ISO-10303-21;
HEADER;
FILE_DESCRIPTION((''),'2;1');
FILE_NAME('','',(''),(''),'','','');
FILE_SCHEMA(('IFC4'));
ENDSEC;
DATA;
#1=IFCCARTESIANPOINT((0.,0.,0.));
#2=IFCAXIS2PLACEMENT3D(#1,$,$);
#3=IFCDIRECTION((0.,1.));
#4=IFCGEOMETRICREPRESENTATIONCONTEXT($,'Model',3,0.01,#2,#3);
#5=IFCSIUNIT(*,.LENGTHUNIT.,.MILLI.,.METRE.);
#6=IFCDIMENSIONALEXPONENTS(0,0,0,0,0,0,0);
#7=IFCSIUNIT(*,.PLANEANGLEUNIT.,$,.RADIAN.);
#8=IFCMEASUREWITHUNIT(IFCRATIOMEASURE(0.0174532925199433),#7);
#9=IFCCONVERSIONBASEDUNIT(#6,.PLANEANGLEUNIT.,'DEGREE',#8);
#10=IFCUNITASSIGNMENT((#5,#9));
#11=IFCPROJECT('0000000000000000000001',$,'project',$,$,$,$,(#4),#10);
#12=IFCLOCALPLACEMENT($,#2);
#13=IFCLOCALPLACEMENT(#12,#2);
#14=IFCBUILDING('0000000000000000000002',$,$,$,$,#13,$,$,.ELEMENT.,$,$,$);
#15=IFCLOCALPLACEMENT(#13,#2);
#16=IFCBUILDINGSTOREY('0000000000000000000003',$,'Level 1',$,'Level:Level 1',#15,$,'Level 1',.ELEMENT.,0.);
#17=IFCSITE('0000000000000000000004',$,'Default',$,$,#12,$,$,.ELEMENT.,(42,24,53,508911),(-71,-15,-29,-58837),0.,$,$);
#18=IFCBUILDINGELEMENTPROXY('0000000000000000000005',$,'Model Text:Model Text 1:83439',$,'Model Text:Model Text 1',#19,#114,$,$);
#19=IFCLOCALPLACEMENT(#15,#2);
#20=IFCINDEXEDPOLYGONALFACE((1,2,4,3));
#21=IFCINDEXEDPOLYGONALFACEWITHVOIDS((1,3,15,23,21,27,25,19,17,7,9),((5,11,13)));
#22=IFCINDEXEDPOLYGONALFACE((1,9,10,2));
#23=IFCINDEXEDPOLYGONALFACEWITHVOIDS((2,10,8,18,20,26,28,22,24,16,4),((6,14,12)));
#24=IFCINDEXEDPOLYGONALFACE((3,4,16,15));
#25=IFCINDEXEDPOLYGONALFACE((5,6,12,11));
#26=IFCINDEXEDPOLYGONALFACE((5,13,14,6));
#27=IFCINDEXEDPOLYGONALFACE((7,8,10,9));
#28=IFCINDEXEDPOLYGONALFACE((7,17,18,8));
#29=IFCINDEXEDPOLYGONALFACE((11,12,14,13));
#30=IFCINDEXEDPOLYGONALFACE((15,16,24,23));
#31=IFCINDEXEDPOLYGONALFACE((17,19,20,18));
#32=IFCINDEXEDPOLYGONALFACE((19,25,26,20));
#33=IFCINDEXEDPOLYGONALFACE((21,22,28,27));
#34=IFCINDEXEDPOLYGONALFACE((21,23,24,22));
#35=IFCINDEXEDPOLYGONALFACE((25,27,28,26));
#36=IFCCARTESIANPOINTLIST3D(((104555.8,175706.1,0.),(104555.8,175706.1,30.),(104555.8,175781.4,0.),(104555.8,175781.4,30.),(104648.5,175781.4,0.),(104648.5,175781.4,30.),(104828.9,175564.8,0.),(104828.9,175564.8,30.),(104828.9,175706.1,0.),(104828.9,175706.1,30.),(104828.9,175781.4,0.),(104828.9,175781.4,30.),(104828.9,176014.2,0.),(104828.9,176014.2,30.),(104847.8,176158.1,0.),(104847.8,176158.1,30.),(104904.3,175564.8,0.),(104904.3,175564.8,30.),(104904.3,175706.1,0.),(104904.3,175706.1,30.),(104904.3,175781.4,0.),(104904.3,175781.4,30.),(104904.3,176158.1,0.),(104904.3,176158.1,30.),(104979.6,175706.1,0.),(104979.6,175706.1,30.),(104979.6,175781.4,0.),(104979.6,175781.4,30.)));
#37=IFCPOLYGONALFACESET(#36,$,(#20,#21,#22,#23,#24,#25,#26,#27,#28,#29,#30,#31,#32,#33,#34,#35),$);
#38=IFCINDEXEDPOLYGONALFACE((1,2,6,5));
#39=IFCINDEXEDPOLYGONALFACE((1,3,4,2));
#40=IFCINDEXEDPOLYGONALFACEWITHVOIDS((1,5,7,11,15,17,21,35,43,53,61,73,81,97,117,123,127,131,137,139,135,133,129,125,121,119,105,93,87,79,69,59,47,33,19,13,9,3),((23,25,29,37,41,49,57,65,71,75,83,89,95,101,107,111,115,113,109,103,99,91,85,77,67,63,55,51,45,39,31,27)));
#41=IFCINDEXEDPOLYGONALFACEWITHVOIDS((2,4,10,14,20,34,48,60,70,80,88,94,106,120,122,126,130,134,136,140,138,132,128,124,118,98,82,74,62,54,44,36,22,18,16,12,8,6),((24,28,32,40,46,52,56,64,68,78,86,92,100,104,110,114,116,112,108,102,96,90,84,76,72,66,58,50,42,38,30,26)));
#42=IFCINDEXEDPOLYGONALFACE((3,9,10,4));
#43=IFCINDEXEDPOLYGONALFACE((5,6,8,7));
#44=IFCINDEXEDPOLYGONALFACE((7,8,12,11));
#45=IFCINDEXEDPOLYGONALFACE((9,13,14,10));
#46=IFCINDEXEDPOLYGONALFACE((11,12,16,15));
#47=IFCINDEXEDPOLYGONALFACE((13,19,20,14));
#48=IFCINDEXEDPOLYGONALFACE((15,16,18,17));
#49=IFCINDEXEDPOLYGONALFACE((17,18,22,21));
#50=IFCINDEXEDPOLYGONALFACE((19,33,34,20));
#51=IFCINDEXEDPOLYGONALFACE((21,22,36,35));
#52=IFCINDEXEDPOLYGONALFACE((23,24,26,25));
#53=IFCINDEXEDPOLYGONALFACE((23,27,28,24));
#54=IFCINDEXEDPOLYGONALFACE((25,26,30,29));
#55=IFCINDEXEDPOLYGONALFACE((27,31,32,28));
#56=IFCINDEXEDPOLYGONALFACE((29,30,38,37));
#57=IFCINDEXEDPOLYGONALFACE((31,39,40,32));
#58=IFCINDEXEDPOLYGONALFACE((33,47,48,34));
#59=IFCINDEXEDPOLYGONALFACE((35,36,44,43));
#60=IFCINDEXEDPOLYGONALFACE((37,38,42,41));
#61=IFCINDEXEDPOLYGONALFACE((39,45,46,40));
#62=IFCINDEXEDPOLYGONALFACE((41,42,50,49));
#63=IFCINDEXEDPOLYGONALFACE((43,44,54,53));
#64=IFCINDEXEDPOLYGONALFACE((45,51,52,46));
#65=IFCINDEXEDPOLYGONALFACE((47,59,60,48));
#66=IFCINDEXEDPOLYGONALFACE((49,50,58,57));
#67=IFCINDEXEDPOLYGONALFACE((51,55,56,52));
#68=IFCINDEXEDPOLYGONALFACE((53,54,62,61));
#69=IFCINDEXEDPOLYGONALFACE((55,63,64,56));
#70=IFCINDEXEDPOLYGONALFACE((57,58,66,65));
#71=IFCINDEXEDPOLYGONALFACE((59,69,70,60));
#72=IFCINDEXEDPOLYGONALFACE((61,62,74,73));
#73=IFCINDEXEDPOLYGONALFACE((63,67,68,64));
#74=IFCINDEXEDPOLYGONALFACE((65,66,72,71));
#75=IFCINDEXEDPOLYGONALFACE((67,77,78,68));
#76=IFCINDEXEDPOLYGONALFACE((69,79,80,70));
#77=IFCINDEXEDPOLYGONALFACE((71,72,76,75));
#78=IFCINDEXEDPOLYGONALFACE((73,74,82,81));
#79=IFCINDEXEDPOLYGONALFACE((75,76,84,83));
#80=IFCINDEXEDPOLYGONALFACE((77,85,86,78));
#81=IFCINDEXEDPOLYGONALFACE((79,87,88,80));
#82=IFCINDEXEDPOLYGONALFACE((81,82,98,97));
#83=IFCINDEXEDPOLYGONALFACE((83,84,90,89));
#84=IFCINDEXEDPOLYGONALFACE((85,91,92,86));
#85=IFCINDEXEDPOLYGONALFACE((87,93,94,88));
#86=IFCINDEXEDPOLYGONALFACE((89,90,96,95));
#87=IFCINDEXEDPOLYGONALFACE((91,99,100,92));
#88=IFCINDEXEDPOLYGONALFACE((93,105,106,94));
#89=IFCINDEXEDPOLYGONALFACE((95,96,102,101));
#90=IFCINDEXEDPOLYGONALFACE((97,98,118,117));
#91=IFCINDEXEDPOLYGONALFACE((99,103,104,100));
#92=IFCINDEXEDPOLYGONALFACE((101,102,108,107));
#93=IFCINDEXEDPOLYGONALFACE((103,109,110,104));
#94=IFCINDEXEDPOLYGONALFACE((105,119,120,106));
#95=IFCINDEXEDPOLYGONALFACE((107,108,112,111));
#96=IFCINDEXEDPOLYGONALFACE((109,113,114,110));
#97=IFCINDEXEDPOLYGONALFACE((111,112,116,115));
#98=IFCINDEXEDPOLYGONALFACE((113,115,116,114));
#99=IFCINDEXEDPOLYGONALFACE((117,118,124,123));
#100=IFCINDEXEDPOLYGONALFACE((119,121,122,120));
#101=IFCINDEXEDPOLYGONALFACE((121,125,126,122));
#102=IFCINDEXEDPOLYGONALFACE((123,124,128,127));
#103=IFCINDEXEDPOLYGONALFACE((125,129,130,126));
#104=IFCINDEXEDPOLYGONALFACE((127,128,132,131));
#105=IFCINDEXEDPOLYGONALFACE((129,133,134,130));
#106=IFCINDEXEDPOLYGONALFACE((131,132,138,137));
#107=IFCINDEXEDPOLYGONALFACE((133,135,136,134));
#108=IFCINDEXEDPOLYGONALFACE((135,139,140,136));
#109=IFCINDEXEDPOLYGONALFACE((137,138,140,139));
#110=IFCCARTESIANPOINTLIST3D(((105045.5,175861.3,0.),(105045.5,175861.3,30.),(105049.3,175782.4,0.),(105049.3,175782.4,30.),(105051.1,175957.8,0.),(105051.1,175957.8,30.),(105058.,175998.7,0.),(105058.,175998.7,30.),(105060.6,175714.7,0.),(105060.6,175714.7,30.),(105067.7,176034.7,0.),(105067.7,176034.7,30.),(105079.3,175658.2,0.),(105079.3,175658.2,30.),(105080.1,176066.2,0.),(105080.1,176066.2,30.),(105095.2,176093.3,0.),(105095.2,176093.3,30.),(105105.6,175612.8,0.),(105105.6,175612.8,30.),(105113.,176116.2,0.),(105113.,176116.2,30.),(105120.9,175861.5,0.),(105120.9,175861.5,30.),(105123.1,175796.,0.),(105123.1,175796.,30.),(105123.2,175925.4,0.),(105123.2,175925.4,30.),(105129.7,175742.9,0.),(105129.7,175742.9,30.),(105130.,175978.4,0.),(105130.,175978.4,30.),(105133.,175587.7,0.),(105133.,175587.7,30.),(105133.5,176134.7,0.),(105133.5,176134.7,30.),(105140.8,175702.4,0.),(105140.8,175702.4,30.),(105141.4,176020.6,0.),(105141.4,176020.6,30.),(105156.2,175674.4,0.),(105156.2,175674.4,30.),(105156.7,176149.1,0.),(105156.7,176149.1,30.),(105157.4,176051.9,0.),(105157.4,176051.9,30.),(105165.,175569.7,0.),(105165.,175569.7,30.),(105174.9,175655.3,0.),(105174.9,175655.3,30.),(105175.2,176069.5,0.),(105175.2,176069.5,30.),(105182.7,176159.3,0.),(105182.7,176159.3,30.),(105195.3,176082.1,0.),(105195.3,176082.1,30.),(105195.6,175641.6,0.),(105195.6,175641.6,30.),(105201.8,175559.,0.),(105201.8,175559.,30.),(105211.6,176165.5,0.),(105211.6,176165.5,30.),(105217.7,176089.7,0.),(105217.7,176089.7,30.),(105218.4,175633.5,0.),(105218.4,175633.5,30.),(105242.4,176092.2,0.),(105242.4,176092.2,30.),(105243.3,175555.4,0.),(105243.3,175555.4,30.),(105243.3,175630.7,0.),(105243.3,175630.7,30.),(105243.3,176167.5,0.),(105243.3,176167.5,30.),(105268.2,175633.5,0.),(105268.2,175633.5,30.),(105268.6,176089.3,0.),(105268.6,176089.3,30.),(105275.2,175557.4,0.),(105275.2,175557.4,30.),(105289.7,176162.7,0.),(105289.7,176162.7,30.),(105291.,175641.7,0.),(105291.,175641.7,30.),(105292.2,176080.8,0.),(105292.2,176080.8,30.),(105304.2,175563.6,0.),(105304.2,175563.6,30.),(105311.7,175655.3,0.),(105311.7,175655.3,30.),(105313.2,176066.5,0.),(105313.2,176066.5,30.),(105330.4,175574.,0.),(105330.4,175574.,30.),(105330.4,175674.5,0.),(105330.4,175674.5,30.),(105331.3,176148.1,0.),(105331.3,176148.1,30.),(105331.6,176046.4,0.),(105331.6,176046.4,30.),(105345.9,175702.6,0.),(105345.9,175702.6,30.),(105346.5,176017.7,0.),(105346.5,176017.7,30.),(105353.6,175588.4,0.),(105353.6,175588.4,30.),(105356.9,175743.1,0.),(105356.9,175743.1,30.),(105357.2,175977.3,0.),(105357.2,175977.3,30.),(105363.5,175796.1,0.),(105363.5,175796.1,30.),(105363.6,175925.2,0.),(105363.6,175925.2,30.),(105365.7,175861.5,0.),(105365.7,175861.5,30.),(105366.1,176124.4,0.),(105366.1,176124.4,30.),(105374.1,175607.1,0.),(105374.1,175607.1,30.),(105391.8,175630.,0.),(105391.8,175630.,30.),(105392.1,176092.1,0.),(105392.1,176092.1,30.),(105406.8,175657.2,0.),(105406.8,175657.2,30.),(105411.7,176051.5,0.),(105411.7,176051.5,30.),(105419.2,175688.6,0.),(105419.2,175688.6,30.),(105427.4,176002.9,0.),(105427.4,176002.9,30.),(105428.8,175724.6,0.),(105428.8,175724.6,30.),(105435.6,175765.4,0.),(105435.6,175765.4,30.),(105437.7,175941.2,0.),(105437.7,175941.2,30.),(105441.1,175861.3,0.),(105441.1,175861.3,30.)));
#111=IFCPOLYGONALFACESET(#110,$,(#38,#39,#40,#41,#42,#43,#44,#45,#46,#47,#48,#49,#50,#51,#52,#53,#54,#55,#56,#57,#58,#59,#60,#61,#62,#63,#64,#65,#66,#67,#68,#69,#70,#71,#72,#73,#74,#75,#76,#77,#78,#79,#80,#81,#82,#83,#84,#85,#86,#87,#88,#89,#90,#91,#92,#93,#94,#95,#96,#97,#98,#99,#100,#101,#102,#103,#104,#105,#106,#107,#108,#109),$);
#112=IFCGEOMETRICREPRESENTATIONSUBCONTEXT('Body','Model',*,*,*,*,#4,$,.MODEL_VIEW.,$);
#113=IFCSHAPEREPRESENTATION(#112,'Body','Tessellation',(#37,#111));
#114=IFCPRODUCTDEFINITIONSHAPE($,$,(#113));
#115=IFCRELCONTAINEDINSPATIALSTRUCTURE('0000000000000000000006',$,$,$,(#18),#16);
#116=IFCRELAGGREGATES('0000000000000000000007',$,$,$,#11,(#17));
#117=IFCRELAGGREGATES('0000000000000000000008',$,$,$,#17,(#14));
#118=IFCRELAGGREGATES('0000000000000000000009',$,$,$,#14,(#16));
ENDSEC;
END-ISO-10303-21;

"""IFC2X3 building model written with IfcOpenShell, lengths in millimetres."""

from ifc_helpers import new_model, entity, si_unit, converted_unit, direction, frame, origin, place, context, subcontext, project, spatial, polyline, outline, extrude, element, save


model = new_model("IFC2X3")

# Units and contexts
model_context = context("Model", 3, precision=0.01, world=origin(), true_north=direction((0.0, 1.0)))
body_context = subcontext(model_context, "Body", "Model", "MODEL_VIEW")
ifc_project = project(units=[si_unit("LENGTHUNIT", "METRE", prefix="MILLI"), converted_unit("PLANEANGLEUNIT", "DEGREE", entity("IfcRatioMeasure", 0.0174532925199433), si_unit("PLANEANGLEUNIT", "RADIAN"), dimensions=[0, 0, 0, 0, 0, 0, 0])], contexts=[model_context])

# Site, building, storey
site_placement = place(None, origin())
site = spatial("IfcSite", under=ifc_project, at=site_placement, Name="Default", CompositionType="ELEMENT", RefLatitude=(42, 24, 53, 508911), RefLongitude=(-71, -15, -29, -58837), RefElevation=0.0)
building_placement = place(site_placement, origin())
building = spatial("IfcBuilding", under=site, at=building_placement, CompositionType="ELEMENT")
storey_placement = place(building_placement, origin())
storey = spatial("IfcBuildingStorey", under=building, at=storey_placement, Name="Level 1", ObjectType="Level:Level 1", LongName="Level 1", CompositionType="ELEMENT", Elevation=0.0)

# Building element proxy
proxy_1_placement = place(storey_placement, origin())
element("IfcBuildingElementProxy", 1, at=proxy_1_placement, inside=storey, Name="Model Text:Model Text 1:83439", ObjectType="Model Text:Model Text 1", context=body_context, shape_type="SweptSolid", body=[
    extrude(outline(polyline([(-6.8, -218.3), (68.5, -218.3), (68.5, -77.1), (143.8, -77.1), (143.8, -1.7), (68.5, -1.7), (68.5, 375.0), (12.0, 375.0), (-280.0, -1.7), (-280.0, -77.1), (-6.8, -77.1), (-6.8, -218.3)]), holes=[polyline([(-6.8, -1.7), (-187.3, -1.7), (-6.8, 231.1), (-6.8, -1.7)])]), frame((104835.8, 175783.1, 0.0)), (0.0, 0.0, 1.0), 30.0),
    extrude(outline(polyline([(-10.6, -198.7), (68.3, -198.7), (136.5, -190.7), (193.9, -174.7), (240.5, -150.6), (266.9, -124.4), (286.3, -93.2), (298.8, -57.0), (304.3, -15.7), (303.8, 16.2), (299.0, 45.5), (289.9, 72.1), (276.6, 96.0), (258.9, 117.3), (236.9, 136.2), (210.4, 152.5), (179.6, 166.3), (144.1, 177.6), (103.7, 186.3), (8.2, 196.4), (-71.8, 196.7), (-134.0, 189.4), (-183.3, 176.1), (-224.7, 158.4), (-258.2, 133.9), (-283.5, 100.3), (-300.1, 59.5), (-307.1, 13.4), (-306.6, -18.4), (-301.8, -47.5), (-292.8, -74.0), (-279.6, -97.9), (-262.0, -119.2), (-240.0, -138.1), (-213.6, -154.5), (-182.8, -168.4), (-147.3, -179.8), (-106.7, -188.6), (-10.6, -198.7)]), holes=[polyline([(-7.2, -123.5), (-71.0, -118.2), (-123.6, -108.8), (-165.2, -95.4), (-195.7, -78.0), (-212.4, -59.4), (-224.1, -38.7), (-230.6, -15.9), (-231.9, 8.9), (-227.8, 35.0), (-218.1, 58.1), (-202.8, 78.4), (-182.0, 95.8), (-152.6, 109.4), (-111.7, 118.1), (-59.4, 122.0), (4.4, 121.1), (69.6, 115.8), (122.2, 106.7), (162.2, 93.7), (189.5, 77.0), (207.7, 57.4), (220.4, 36.0), (227.5, 12.8), (229.1, -12.1), (225.2, -36.8), (215.9, -59.2), (201.3, -79.3), (181.4, -97.1), (152.6, -111.2), (111.6, -120.3), (58.3, -124.4), (-7.2, -123.5)])]), frame((105244.6, 175860.1, 0.0), z_axis=(0.0, 0.0, 1.0), x_axis=(0.047515, -0.998871, 0.0)), (0.0, 0.0, 1.0), 30.0),
])

save(model, "model.ifc")
